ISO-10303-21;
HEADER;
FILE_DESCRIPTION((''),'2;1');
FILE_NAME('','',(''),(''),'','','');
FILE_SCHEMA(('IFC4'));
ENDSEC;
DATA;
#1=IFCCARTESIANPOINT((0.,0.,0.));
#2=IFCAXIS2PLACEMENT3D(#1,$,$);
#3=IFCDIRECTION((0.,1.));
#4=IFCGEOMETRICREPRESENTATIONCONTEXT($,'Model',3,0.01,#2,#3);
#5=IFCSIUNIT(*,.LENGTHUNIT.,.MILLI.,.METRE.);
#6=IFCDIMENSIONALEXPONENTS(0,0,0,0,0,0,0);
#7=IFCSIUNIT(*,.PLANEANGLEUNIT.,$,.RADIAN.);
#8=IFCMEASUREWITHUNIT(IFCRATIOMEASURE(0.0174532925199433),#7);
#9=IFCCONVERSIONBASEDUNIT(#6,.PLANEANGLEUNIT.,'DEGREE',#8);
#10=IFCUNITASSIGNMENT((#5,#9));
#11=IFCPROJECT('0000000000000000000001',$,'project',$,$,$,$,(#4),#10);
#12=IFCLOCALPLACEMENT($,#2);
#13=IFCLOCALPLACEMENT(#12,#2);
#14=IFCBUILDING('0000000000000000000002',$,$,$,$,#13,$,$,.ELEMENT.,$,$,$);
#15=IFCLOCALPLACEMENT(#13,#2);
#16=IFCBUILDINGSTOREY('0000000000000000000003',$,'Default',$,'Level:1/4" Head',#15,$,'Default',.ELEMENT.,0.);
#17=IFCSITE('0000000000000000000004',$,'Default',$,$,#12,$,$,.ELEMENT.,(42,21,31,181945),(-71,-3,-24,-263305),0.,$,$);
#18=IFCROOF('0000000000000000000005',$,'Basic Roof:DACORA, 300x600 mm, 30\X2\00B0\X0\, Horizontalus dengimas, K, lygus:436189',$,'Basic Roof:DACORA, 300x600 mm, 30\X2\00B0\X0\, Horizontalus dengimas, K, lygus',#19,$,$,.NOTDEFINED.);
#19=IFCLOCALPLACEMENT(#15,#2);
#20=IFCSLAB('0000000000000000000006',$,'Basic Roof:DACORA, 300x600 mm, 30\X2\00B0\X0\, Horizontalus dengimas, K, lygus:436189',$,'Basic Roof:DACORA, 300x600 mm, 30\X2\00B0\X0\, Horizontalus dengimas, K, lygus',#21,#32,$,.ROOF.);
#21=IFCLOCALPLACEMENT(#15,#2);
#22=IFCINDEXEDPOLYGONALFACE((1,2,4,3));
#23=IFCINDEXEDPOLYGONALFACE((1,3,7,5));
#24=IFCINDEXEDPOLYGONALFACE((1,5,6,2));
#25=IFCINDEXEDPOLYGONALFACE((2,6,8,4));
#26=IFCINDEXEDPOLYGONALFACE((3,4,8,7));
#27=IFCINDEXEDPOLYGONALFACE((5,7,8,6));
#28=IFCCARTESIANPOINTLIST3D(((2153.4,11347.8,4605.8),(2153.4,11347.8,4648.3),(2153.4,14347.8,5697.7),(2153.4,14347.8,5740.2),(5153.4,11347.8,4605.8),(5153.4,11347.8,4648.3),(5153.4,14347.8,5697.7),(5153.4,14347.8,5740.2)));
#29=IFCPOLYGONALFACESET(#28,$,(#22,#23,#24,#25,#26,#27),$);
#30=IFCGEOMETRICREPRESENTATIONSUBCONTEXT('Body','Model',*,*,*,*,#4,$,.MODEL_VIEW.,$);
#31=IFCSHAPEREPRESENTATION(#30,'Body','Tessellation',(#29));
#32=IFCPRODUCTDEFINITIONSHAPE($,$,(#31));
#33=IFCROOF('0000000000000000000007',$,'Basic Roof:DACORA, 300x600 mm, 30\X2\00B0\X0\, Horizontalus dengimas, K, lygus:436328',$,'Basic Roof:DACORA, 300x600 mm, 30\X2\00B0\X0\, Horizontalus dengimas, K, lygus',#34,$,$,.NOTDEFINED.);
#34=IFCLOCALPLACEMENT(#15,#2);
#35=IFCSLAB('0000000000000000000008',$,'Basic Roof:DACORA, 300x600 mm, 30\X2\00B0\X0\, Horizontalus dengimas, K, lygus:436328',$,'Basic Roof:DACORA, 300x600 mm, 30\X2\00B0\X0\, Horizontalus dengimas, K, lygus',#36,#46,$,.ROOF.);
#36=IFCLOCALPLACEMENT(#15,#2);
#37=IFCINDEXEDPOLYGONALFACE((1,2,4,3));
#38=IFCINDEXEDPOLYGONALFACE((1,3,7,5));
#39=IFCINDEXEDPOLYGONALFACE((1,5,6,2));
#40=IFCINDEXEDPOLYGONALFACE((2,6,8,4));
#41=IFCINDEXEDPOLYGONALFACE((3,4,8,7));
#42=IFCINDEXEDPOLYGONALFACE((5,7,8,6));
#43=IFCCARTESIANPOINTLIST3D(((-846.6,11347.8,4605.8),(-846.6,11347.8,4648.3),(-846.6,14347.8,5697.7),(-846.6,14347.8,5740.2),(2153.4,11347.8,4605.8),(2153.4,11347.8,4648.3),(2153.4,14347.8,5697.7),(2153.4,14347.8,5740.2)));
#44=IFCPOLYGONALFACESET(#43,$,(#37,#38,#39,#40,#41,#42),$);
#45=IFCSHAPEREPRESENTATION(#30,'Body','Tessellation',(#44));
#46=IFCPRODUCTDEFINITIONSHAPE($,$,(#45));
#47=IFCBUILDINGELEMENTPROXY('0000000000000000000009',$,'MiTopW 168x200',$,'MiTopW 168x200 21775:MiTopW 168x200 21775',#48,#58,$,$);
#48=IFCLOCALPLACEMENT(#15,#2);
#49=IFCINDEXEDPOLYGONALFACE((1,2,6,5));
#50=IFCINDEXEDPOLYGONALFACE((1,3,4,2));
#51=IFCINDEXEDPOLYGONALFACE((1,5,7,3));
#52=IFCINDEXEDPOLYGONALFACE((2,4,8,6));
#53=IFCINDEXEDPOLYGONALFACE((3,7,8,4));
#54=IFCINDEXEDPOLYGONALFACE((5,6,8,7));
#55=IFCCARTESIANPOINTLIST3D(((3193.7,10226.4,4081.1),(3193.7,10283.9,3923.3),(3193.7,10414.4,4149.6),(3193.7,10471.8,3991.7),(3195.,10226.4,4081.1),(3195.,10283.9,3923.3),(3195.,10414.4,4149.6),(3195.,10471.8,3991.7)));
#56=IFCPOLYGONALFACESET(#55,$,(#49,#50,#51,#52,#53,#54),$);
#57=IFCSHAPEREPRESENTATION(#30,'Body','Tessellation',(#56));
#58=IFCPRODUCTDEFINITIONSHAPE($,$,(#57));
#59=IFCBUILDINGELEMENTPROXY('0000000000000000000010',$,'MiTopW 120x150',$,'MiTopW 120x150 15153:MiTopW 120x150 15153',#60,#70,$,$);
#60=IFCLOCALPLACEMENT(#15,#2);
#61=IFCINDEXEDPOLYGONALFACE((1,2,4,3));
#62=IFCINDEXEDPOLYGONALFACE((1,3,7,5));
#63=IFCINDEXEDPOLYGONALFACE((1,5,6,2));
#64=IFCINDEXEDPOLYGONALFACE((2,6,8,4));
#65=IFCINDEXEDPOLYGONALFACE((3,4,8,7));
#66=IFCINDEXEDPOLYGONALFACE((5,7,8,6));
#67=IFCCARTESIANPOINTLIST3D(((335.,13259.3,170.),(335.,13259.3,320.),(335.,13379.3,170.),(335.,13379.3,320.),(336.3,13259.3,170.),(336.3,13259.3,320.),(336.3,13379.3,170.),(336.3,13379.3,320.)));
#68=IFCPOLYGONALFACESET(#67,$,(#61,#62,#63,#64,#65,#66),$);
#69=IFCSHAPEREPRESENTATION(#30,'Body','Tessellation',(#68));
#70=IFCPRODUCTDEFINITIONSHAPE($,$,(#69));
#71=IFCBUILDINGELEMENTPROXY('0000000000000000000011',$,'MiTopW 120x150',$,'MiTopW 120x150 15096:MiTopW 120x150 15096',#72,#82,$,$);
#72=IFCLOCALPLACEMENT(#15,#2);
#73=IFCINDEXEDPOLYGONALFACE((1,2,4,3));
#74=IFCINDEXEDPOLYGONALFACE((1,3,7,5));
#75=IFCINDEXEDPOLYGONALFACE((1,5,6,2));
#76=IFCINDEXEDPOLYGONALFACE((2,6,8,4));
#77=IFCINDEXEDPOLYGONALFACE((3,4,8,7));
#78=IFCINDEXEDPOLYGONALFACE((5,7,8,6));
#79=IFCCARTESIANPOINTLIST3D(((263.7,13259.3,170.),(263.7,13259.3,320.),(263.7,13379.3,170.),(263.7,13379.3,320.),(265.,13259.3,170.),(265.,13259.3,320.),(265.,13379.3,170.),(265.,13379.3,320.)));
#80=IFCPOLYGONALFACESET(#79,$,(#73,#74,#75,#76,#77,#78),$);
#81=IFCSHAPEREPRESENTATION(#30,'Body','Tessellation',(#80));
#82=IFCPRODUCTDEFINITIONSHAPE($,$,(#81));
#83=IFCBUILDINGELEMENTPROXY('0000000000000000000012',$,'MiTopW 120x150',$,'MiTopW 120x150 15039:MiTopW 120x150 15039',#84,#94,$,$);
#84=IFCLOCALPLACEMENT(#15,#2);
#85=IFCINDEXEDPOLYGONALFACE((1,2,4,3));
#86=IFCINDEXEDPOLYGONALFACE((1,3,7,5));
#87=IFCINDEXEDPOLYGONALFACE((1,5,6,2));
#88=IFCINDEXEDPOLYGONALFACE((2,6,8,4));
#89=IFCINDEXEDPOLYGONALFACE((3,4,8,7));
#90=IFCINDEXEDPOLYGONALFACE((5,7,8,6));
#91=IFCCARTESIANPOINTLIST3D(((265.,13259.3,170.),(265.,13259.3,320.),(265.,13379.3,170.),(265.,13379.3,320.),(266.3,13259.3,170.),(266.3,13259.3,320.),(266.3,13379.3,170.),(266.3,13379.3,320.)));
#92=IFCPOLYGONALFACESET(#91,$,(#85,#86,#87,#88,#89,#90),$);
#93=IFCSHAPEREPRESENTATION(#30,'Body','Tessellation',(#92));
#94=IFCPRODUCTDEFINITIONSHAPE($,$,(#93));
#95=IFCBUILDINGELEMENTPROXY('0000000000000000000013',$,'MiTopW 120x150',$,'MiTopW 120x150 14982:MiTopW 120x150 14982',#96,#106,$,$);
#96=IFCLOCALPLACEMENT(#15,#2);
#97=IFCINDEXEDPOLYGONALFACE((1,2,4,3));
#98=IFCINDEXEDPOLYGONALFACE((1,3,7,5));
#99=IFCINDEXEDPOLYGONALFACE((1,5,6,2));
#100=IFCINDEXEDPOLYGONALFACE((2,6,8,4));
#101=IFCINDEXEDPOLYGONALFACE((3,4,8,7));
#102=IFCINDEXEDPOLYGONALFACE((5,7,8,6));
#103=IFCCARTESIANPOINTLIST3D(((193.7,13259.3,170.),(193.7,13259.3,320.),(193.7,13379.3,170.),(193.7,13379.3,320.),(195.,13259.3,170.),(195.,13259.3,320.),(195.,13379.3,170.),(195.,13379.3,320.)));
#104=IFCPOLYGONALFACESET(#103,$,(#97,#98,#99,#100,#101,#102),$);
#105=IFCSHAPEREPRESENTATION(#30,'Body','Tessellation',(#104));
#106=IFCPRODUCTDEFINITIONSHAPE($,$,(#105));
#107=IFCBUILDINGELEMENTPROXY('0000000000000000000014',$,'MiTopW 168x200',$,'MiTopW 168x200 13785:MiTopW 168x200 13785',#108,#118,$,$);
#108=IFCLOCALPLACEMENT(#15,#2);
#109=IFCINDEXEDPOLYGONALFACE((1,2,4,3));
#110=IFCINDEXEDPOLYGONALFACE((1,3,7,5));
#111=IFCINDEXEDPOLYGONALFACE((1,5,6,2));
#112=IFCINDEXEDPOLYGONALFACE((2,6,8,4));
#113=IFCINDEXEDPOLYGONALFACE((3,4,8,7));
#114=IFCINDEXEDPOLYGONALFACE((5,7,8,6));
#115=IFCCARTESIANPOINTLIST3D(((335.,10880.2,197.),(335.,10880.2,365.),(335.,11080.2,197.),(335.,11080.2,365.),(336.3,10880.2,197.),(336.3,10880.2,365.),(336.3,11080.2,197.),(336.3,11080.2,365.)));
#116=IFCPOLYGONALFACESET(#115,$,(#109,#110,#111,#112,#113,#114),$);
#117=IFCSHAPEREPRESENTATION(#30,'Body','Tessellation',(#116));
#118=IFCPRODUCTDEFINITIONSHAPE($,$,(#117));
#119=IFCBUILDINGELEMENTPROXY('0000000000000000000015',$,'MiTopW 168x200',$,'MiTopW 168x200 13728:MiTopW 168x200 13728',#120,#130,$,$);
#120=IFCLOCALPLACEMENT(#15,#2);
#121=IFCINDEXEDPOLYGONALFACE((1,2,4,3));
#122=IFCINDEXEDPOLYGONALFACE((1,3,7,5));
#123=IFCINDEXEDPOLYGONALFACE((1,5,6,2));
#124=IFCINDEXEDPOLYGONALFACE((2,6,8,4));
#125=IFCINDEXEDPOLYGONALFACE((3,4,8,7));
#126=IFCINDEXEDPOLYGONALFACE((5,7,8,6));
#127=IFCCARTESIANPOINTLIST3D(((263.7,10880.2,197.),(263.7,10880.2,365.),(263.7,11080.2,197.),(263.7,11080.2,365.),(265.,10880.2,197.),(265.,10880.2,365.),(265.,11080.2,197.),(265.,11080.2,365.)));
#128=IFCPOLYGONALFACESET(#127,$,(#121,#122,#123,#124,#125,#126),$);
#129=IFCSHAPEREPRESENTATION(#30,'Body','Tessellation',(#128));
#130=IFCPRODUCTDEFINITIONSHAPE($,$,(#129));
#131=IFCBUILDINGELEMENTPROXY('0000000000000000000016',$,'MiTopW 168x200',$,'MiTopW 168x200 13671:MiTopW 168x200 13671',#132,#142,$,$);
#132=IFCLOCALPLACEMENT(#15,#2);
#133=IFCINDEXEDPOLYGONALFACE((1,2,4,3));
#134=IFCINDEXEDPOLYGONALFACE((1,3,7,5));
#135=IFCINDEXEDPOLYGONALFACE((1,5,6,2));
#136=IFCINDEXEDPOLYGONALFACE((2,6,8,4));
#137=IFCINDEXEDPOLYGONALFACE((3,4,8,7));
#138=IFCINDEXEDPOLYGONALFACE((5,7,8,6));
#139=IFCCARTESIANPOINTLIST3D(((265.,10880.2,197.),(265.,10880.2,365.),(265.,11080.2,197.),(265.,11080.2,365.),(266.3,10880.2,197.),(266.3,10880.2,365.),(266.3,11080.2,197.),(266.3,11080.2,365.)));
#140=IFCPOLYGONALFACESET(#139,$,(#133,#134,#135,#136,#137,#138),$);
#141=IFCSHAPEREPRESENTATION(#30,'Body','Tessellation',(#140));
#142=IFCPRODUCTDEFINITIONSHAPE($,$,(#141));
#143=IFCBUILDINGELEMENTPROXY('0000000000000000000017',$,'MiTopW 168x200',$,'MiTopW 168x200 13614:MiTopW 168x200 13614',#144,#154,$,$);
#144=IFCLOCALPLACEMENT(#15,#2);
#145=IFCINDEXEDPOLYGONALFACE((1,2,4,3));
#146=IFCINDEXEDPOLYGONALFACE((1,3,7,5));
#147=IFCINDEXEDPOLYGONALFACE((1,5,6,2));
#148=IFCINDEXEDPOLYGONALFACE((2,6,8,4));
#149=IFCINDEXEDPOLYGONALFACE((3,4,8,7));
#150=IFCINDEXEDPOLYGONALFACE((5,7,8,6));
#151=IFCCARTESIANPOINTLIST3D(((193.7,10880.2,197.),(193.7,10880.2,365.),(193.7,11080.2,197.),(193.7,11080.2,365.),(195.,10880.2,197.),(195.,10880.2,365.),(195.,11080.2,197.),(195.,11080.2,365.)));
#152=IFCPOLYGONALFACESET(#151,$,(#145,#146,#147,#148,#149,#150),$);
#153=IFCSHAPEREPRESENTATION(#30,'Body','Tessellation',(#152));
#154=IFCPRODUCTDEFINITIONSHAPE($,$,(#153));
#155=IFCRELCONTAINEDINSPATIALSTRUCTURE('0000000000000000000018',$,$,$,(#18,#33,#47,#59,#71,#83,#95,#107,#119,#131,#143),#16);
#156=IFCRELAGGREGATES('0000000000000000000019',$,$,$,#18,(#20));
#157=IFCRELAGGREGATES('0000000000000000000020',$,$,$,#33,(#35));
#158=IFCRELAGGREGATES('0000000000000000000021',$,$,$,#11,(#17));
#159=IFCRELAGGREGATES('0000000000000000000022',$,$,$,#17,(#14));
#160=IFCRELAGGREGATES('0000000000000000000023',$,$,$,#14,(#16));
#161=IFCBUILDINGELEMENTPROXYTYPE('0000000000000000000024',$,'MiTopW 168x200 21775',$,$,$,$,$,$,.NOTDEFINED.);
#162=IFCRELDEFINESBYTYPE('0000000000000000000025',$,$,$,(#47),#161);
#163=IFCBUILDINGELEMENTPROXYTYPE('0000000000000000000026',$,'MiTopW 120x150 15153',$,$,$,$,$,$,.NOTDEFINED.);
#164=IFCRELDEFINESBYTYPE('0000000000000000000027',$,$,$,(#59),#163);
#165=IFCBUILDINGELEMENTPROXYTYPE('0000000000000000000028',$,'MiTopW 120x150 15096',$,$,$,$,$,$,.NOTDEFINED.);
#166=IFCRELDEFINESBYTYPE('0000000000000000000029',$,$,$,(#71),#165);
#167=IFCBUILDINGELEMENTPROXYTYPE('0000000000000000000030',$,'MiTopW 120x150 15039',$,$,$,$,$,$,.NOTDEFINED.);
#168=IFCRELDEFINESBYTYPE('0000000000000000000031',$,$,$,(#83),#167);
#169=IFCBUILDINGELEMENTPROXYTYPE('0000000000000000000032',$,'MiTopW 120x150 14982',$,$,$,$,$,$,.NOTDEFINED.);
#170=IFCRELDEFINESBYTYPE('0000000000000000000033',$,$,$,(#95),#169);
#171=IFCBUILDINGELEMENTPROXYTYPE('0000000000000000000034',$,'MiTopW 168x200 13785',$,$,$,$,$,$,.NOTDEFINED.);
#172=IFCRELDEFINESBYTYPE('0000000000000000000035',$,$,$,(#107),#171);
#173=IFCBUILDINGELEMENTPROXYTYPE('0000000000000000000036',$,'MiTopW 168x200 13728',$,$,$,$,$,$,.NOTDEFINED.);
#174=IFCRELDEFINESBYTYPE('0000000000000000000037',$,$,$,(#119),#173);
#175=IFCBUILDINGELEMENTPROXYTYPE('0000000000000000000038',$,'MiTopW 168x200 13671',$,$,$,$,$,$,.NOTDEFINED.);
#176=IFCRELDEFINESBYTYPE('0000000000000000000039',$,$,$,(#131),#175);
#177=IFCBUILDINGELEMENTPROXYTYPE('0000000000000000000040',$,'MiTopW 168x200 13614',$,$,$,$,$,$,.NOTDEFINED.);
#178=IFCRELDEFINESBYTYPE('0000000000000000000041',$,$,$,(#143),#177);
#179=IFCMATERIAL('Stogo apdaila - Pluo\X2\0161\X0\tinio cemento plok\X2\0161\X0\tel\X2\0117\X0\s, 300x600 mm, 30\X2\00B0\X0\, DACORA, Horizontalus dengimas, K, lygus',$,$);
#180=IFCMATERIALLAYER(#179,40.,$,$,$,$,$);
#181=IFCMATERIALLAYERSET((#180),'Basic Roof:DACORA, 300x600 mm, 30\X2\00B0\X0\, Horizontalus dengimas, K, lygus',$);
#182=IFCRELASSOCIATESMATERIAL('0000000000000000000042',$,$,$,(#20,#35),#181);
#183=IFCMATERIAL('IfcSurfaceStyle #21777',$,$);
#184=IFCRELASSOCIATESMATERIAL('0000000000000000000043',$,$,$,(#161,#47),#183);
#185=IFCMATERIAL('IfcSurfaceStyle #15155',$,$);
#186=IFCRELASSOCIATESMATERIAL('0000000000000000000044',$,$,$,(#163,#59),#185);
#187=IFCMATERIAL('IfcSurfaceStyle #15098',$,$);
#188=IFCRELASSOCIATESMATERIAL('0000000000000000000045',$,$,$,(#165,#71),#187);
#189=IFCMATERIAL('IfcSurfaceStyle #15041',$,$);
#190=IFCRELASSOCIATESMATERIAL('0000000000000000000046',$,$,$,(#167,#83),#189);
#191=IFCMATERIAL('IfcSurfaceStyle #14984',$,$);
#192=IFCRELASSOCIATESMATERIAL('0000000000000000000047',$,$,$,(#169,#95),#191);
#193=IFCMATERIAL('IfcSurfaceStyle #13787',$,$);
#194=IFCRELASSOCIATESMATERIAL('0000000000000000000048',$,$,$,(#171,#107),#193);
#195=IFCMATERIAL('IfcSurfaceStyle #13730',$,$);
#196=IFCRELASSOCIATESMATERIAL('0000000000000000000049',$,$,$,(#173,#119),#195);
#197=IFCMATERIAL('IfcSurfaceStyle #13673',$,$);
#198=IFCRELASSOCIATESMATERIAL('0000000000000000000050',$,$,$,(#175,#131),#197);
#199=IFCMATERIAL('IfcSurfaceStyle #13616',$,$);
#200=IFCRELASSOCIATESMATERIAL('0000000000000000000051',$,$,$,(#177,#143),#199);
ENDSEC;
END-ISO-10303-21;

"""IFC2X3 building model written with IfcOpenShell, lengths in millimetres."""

from ifc_helpers import new_model, entity, si_unit, converted_unit, direction, frame, frame_2d, origin, origin_2d_with_axis, place, context, subcontext, project, spatial, polyline, rectangle, outline, extrude, source, transform, mapped, material, layer, layer_set, type_object, type_shapes, element, aggregate, save


model = new_model("IFC2X3")

# Units and contexts
model_context = context("Model", 3, precision=0.01, world=origin(), true_north=direction((0.0, 1.0)))
body_context = subcontext(model_context, "Body", "Model", "MODEL_VIEW")
ifc_project = project(units=[si_unit("LENGTHUNIT", "METRE", prefix="MILLI"), converted_unit("PLANEANGLEUNIT", "DEGREE", entity("IfcRatioMeasure", 0.0174532925199433), si_unit("PLANEANGLEUNIT", "RADIAN"), dimensions=[0, 0, 0, 0, 0, 0, 0])], contexts=[model_context])

# Site, building, storey
site_placement = place(None, origin())
site = spatial("IfcSite", under=ifc_project, at=site_placement, Name="Default", CompositionType="ELEMENT", RefLatitude=(42, 21, 31, 181945), RefLongitude=(-71, -3, -24, -263305), RefElevation=0.0)
building_placement = place(site_placement, origin())
building = spatial("IfcBuilding", under=site, at=building_placement, CompositionType="ELEMENT")
storey_placement = place(building_placement, origin())
storey = spatial("IfcBuildingStorey", under=building, at=storey_placement, Name="Default", ObjectType="Level:1/4\" Head", LongName="Default", CompositionType="ELEMENT", Elevation=0.0)

# Roofs, slabs
roof_1_placement = place(storey_placement, frame((2153.4, 11347.8, 4605.8)))
roof_1 = element("IfcRoof", 1, at=roof_1_placement, inside=storey, Name="Basic Roof:DACORA, 300x600 mm, 30°, Horizontalus dengimas, K, lygus:436189", ObjectType="Basic Roof:DACORA, 300x600 mm, 30°, Horizontalus dengimas, K, lygus", ShapeType="NOTDEFINED")
ifc_material_1 = material(Name="Stogo apdaila - Pluoštinio cemento plokštelės, 300x600 mm, 30°, DACORA, Horizontalus dengimas, K, lygus")
ifc_layer = layer(ifc_material_1, 40.0)
ifc_layer_set = layer_set([ifc_layer], Name="Basic Roof:DACORA, 300x600 mm, 30°, Horizontalus dengimas, K, lygus")
slab_1_placement = place(roof_1_placement, origin())
slab_1 = element("IfcSlab", 2, at=slab_1_placement, material=ifc_layer_set, Name="Basic Roof:DACORA, 300x600 mm, 30°, Horizontalus dengimas, K, lygus:436189", ObjectType="Basic Roof:DACORA, 300x600 mm, 30°, Horizontalus dengimas, K, lygus", PredefinedType="ROOF", context=body_context, shape_type="SweptSolid", body=[
    extrude(rectangle(XDim=3192.5, YDim=3000.0, at=frame_2d((0.0, 0.0), x_axis=(0.0, -1.0))), frame((1500.0, 1500.0, 546.0), z_axis=(0.0, -0.34202, 0.939693), x_axis=(1.0, 0.0, 0.0)), (0.0, 0.34202, 0.939693), 42.6),
])
aggregate(roof_1, [slab_1])
roof_2_placement = place(storey_placement, frame((-846.6, 11347.8, 4605.8)))
roof_2 = element("IfcRoof", 3, at=roof_2_placement, inside=storey, Name="Basic Roof:DACORA, 300x600 mm, 30°, Horizontalus dengimas, K, lygus:436328", ObjectType="Basic Roof:DACORA, 300x600 mm, 30°, Horizontalus dengimas, K, lygus", ShapeType="NOTDEFINED")
slab_2_placement = place(roof_2_placement, origin())
slab_2 = element("IfcSlab", 4, at=slab_2_placement, material=ifc_layer_set, Name="Basic Roof:DACORA, 300x600 mm, 30°, Horizontalus dengimas, K, lygus:436328", ObjectType="Basic Roof:DACORA, 300x600 mm, 30°, Horizontalus dengimas, K, lygus", PredefinedType="ROOF", context=body_context, shape_type="SweptSolid", body=[
    extrude(rectangle(XDim=3192.5, YDim=3000.0, at=frame_2d((0.0, 0.0), x_axis=(0.0, -1.0))), frame((1500.0, 1500.0, 546.0), z_axis=(0.0, -0.34202, 0.939693), x_axis=(1.0, 0.0, 0.0)), (0.0, 0.34202, 0.939693), 42.6),
])
aggregate(roof_2, [slab_2])

# Building element proxies
ifc_material_2 = material(Name="IfcSurfaceStyle #21777")
building_element_proxy_type_1 = type_object("IfcBuildingElementProxyType", Name="MiTopW 168x200 21775", PredefinedType="NOTDEFINED", material=ifc_material_2)
shared_shape_1 = source(origin(), body_context, "Body", "SweptSolid", [
    extrude(outline(polyline([(-100.0, -84.0), (100.0, -84.0), (100.0, 84.0), (-100.0, 84.0), (-100.0, -84.0)])), frame((100.0, 84.0, 0.0), z_axis=(0.0, 0.0, 1.0), x_axis=(-1.0, 0.0, 0.0)), (0.0, 0.0, 1.0), 1.3),
])
type_shapes(building_element_proxy_type_1, [shared_shape_1])
proxy_1_placement = place(building_placement, frame((3195.0, 10226.4, 4081.1), z_axis=(-1.0, 0.0, 0.0), x_axis=(0.0, 0.939693, 0.34202)))
element("IfcBuildingElementProxy", 5, at=proxy_1_placement, inside=storey, type_object=building_element_proxy_type_1, material=ifc_material_2, Name="MiTopW 168x200", ObjectType="MiTopW 168x200 21775:MiTopW 168x200 21775", context=body_context, shape_type="MappedRepresentation", body=[
    mapped(shared_shape_1, transform((0.0, 0.0, 0.0), scale=1.0)),
])
ifc_material_3 = material(Name="IfcSurfaceStyle #15155")
building_element_proxy_type_2 = type_object("IfcBuildingElementProxyType", Name="MiTopW 120x150 15153", PredefinedType="NOTDEFINED", material=ifc_material_3)
shared_shape_2 = source(origin(), body_context, "Body", "SweptSolid", [
    extrude(rectangle(XDim=150.0, YDim=120.0, at=origin_2d_with_axis()), frame((75.0, 60.0, 0.0), z_axis=(0.0, 0.0, 1.0), x_axis=(-1.0, 0.0, 0.0)), (0.0, 0.0, 1.0), 1.3),
])
type_shapes(building_element_proxy_type_2, [shared_shape_2])
proxy_2_placement = place(building_placement, frame((336.3, 13259.3, 170.0), z_axis=(-1.0, 0.0, 0.0), x_axis=(0.0, 0.0, 1.0)))
element("IfcBuildingElementProxy", 6, at=proxy_2_placement, inside=storey, type_object=building_element_proxy_type_2, material=ifc_material_3, Name="MiTopW 120x150", ObjectType="MiTopW 120x150 15153:MiTopW 120x150 15153", context=body_context, shape_type="MappedRepresentation", body=[
    mapped(shared_shape_2, transform((0.0, 0.0, 0.0), scale=1.0)),
])
ifc_material_4 = material(Name="IfcSurfaceStyle #15098")
building_element_proxy_type_3 = type_object("IfcBuildingElementProxyType", Name="MiTopW 120x150 15096", PredefinedType="NOTDEFINED", material=ifc_material_4)
shared_shape_3 = source(origin(), body_context, "Body", "SweptSolid", [
    extrude(rectangle(XDim=150.0, YDim=120.0, at=origin_2d_with_axis()), frame((75.0, 60.0, 0.0), z_axis=(0.0, 0.0, 1.0), x_axis=(-1.0, 0.0, 0.0)), (0.0, 0.0, 1.0), 1.3),
])
type_shapes(building_element_proxy_type_3, [shared_shape_3])
proxy_3_placement = place(building_placement, frame((265.0, 13259.3, 170.0), z_axis=(-1.0, 0.0, 0.0), x_axis=(0.0, 0.0, 1.0)))
element("IfcBuildingElementProxy", 7, at=proxy_3_placement, inside=storey, type_object=building_element_proxy_type_3, material=ifc_material_4, Name="MiTopW 120x150", ObjectType="MiTopW 120x150 15096:MiTopW 120x150 15096", context=body_context, shape_type="MappedRepresentation", body=[
    mapped(shared_shape_3, transform((0.0, 0.0, 0.0), scale=1.0)),
])
ifc_material_5 = material(Name="IfcSurfaceStyle #15041")
building_element_proxy_type_4 = type_object("IfcBuildingElementProxyType", Name="MiTopW 120x150 15039", PredefinedType="NOTDEFINED", material=ifc_material_5)
shared_shape_4 = source(origin(), body_context, "Body", "SweptSolid", [
    extrude(rectangle(XDim=150.0, YDim=120.0, at=origin_2d_with_axis()), frame((75.0, 60.0, 0.0), z_axis=(0.0, 0.0, 1.0), x_axis=(-1.0, 0.0, 0.0)), (0.0, 0.0, 1.0), 1.3),
])
type_shapes(building_element_proxy_type_4, [shared_shape_4])
proxy_4_placement = place(building_placement, frame((266.3, 13259.3, 170.0), z_axis=(-1.0, 0.0, 0.0), x_axis=(0.0, 0.0, 1.0)))
element("IfcBuildingElementProxy", 8, at=proxy_4_placement, inside=storey, type_object=building_element_proxy_type_4, material=ifc_material_5, Name="MiTopW 120x150", ObjectType="MiTopW 120x150 15039:MiTopW 120x150 15039", context=body_context, shape_type="MappedRepresentation", body=[
    mapped(shared_shape_4, transform((0.0, 0.0, 0.0), scale=1.0)),
])
ifc_material_6 = material(Name="IfcSurfaceStyle #14984")
building_element_proxy_type_5 = type_object("IfcBuildingElementProxyType", Name="MiTopW 120x150 14982", PredefinedType="NOTDEFINED", material=ifc_material_6)
shared_shape_5 = source(origin(), body_context, "Body", "SweptSolid", [
    extrude(rectangle(XDim=150.0, YDim=120.0, at=origin_2d_with_axis()), frame((75.0, 60.0, 0.0), z_axis=(0.0, 0.0, 1.0), x_axis=(-1.0, 0.0, 0.0)), (0.0, 0.0, 1.0), 1.3),
])
type_shapes(building_element_proxy_type_5, [shared_shape_5])
proxy_5_placement = place(building_placement, frame((195.0, 13259.3, 170.0), z_axis=(-1.0, 0.0, 0.0), x_axis=(0.0, 0.0, 1.0)))
element("IfcBuildingElementProxy", 9, at=proxy_5_placement, inside=storey, type_object=building_element_proxy_type_5, material=ifc_material_6, Name="MiTopW 120x150", ObjectType="MiTopW 120x150 14982:MiTopW 120x150 14982", context=body_context, shape_type="MappedRepresentation", body=[
    mapped(shared_shape_5, transform((0.0, 0.0, 0.0), scale=1.0)),
])
ifc_material_7 = material(Name="IfcSurfaceStyle #13787")
building_element_proxy_type_6 = type_object("IfcBuildingElementProxyType", Name="MiTopW 168x200 13785", PredefinedType="NOTDEFINED", material=ifc_material_7)
shared_shape_6 = source(origin(), body_context, "Body", "SweptSolid", [
    extrude(rectangle(XDim=200.0, YDim=168.0, at=origin_2d_with_axis()), frame((100.0, 84.0, 0.0), z_axis=(0.0, 0.0, 1.0), x_axis=(-1.0, 0.0, 0.0)), (0.0, 0.0, 1.0), 1.3),
])
type_shapes(building_element_proxy_type_6, [shared_shape_6])
proxy_6_placement = place(building_placement, frame((336.3, 10880.2, 365.0), z_axis=(-1.0, 0.0, 0.0), x_axis=(0.0, 1.0, 0.0)))
element("IfcBuildingElementProxy", 10, at=proxy_6_placement, inside=storey, type_object=building_element_proxy_type_6, material=ifc_material_7, Name="MiTopW 168x200", ObjectType="MiTopW 168x200 13785:MiTopW 168x200 13785", context=body_context, shape_type="MappedRepresentation", body=[
    mapped(shared_shape_6, transform((0.0, 0.0, 0.0), scale=1.0)),
])
ifc_material_8 = material(Name="IfcSurfaceStyle #13730")
building_element_proxy_type_7 = type_object("IfcBuildingElementProxyType", Name="MiTopW 168x200 13728", PredefinedType="NOTDEFINED", material=ifc_material_8)
shared_shape_7 = source(origin(), body_context, "Body", "SweptSolid", [
    extrude(rectangle(XDim=200.0, YDim=168.0, at=origin_2d_with_axis()), frame((100.0, 84.0, 0.0), z_axis=(0.0, 0.0, 1.0), x_axis=(-1.0, 0.0, 0.0)), (0.0, 0.0, 1.0), 1.3),
])
type_shapes(building_element_proxy_type_7, [shared_shape_7])
proxy_7_placement = place(building_placement, frame((265.0, 10880.2, 365.0), z_axis=(-1.0, 0.0, 0.0), x_axis=(0.0, 1.0, 0.0)))
element("IfcBuildingElementProxy", 11, at=proxy_7_placement, inside=storey, type_object=building_element_proxy_type_7, material=ifc_material_8, Name="MiTopW 168x200", ObjectType="MiTopW 168x200 13728:MiTopW 168x200 13728", context=body_context, shape_type="MappedRepresentation", body=[
    mapped(shared_shape_7, transform((0.0, 0.0, 0.0), scale=1.0)),
])
ifc_material_9 = material(Name="IfcSurfaceStyle #13673")
building_element_proxy_type_8 = type_object("IfcBuildingElementProxyType", Name="MiTopW 168x200 13671", PredefinedType="NOTDEFINED", material=ifc_material_9)
shared_shape_8 = source(origin(), body_context, "Body", "SweptSolid", [
    extrude(rectangle(XDim=200.0, YDim=168.0, at=origin_2d_with_axis()), frame((100.0, 84.0, 0.0), z_axis=(0.0, 0.0, 1.0), x_axis=(-1.0, 0.0, 0.0)), (0.0, 0.0, 1.0), 1.3),
])
type_shapes(building_element_proxy_type_8, [shared_shape_8])
proxy_8_placement = place(building_placement, frame((266.3, 10880.2, 365.0), z_axis=(-1.0, 0.0, 0.0), x_axis=(0.0, 1.0, 0.0)))
element("IfcBuildingElementProxy", 12, at=proxy_8_placement, inside=storey, type_object=building_element_proxy_type_8, material=ifc_material_9, Name="MiTopW 168x200", ObjectType="MiTopW 168x200 13671:MiTopW 168x200 13671", context=body_context, shape_type="MappedRepresentation", body=[
    mapped(shared_shape_8, transform((0.0, 0.0, 0.0), scale=1.0)),
])
ifc_material_10 = material(Name="IfcSurfaceStyle #13616")
building_element_proxy_type_9 = type_object("IfcBuildingElementProxyType", Name="MiTopW 168x200 13614", PredefinedType="NOTDEFINED", material=ifc_material_10)
shared_shape_9 = source(origin(), body_context, "Body", "SweptSolid", [
    extrude(rectangle(XDim=200.0, YDim=168.0, at=origin_2d_with_axis()), frame((100.0, 84.0, 0.0), z_axis=(0.0, 0.0, 1.0), x_axis=(-1.0, 0.0, 0.0)), (0.0, 0.0, 1.0), 1.3),
])
type_shapes(building_element_proxy_type_9, [shared_shape_9])
proxy_9_placement = place(building_placement, frame((195.0, 10880.2, 365.0), z_axis=(-1.0, 0.0, 0.0), x_axis=(0.0, 1.0, 0.0)))
element("IfcBuildingElementProxy", 13, at=proxy_9_placement, inside=storey, type_object=building_element_proxy_type_9, material=ifc_material_10, Name="MiTopW 168x200", ObjectType="MiTopW 168x200 13614:MiTopW 168x200 13614", context=body_context, shape_type="MappedRepresentation", body=[
    mapped(shared_shape_9, transform((0.0, 0.0, 0.0), scale=1.0)),
])

save(model, "model.ifc")
